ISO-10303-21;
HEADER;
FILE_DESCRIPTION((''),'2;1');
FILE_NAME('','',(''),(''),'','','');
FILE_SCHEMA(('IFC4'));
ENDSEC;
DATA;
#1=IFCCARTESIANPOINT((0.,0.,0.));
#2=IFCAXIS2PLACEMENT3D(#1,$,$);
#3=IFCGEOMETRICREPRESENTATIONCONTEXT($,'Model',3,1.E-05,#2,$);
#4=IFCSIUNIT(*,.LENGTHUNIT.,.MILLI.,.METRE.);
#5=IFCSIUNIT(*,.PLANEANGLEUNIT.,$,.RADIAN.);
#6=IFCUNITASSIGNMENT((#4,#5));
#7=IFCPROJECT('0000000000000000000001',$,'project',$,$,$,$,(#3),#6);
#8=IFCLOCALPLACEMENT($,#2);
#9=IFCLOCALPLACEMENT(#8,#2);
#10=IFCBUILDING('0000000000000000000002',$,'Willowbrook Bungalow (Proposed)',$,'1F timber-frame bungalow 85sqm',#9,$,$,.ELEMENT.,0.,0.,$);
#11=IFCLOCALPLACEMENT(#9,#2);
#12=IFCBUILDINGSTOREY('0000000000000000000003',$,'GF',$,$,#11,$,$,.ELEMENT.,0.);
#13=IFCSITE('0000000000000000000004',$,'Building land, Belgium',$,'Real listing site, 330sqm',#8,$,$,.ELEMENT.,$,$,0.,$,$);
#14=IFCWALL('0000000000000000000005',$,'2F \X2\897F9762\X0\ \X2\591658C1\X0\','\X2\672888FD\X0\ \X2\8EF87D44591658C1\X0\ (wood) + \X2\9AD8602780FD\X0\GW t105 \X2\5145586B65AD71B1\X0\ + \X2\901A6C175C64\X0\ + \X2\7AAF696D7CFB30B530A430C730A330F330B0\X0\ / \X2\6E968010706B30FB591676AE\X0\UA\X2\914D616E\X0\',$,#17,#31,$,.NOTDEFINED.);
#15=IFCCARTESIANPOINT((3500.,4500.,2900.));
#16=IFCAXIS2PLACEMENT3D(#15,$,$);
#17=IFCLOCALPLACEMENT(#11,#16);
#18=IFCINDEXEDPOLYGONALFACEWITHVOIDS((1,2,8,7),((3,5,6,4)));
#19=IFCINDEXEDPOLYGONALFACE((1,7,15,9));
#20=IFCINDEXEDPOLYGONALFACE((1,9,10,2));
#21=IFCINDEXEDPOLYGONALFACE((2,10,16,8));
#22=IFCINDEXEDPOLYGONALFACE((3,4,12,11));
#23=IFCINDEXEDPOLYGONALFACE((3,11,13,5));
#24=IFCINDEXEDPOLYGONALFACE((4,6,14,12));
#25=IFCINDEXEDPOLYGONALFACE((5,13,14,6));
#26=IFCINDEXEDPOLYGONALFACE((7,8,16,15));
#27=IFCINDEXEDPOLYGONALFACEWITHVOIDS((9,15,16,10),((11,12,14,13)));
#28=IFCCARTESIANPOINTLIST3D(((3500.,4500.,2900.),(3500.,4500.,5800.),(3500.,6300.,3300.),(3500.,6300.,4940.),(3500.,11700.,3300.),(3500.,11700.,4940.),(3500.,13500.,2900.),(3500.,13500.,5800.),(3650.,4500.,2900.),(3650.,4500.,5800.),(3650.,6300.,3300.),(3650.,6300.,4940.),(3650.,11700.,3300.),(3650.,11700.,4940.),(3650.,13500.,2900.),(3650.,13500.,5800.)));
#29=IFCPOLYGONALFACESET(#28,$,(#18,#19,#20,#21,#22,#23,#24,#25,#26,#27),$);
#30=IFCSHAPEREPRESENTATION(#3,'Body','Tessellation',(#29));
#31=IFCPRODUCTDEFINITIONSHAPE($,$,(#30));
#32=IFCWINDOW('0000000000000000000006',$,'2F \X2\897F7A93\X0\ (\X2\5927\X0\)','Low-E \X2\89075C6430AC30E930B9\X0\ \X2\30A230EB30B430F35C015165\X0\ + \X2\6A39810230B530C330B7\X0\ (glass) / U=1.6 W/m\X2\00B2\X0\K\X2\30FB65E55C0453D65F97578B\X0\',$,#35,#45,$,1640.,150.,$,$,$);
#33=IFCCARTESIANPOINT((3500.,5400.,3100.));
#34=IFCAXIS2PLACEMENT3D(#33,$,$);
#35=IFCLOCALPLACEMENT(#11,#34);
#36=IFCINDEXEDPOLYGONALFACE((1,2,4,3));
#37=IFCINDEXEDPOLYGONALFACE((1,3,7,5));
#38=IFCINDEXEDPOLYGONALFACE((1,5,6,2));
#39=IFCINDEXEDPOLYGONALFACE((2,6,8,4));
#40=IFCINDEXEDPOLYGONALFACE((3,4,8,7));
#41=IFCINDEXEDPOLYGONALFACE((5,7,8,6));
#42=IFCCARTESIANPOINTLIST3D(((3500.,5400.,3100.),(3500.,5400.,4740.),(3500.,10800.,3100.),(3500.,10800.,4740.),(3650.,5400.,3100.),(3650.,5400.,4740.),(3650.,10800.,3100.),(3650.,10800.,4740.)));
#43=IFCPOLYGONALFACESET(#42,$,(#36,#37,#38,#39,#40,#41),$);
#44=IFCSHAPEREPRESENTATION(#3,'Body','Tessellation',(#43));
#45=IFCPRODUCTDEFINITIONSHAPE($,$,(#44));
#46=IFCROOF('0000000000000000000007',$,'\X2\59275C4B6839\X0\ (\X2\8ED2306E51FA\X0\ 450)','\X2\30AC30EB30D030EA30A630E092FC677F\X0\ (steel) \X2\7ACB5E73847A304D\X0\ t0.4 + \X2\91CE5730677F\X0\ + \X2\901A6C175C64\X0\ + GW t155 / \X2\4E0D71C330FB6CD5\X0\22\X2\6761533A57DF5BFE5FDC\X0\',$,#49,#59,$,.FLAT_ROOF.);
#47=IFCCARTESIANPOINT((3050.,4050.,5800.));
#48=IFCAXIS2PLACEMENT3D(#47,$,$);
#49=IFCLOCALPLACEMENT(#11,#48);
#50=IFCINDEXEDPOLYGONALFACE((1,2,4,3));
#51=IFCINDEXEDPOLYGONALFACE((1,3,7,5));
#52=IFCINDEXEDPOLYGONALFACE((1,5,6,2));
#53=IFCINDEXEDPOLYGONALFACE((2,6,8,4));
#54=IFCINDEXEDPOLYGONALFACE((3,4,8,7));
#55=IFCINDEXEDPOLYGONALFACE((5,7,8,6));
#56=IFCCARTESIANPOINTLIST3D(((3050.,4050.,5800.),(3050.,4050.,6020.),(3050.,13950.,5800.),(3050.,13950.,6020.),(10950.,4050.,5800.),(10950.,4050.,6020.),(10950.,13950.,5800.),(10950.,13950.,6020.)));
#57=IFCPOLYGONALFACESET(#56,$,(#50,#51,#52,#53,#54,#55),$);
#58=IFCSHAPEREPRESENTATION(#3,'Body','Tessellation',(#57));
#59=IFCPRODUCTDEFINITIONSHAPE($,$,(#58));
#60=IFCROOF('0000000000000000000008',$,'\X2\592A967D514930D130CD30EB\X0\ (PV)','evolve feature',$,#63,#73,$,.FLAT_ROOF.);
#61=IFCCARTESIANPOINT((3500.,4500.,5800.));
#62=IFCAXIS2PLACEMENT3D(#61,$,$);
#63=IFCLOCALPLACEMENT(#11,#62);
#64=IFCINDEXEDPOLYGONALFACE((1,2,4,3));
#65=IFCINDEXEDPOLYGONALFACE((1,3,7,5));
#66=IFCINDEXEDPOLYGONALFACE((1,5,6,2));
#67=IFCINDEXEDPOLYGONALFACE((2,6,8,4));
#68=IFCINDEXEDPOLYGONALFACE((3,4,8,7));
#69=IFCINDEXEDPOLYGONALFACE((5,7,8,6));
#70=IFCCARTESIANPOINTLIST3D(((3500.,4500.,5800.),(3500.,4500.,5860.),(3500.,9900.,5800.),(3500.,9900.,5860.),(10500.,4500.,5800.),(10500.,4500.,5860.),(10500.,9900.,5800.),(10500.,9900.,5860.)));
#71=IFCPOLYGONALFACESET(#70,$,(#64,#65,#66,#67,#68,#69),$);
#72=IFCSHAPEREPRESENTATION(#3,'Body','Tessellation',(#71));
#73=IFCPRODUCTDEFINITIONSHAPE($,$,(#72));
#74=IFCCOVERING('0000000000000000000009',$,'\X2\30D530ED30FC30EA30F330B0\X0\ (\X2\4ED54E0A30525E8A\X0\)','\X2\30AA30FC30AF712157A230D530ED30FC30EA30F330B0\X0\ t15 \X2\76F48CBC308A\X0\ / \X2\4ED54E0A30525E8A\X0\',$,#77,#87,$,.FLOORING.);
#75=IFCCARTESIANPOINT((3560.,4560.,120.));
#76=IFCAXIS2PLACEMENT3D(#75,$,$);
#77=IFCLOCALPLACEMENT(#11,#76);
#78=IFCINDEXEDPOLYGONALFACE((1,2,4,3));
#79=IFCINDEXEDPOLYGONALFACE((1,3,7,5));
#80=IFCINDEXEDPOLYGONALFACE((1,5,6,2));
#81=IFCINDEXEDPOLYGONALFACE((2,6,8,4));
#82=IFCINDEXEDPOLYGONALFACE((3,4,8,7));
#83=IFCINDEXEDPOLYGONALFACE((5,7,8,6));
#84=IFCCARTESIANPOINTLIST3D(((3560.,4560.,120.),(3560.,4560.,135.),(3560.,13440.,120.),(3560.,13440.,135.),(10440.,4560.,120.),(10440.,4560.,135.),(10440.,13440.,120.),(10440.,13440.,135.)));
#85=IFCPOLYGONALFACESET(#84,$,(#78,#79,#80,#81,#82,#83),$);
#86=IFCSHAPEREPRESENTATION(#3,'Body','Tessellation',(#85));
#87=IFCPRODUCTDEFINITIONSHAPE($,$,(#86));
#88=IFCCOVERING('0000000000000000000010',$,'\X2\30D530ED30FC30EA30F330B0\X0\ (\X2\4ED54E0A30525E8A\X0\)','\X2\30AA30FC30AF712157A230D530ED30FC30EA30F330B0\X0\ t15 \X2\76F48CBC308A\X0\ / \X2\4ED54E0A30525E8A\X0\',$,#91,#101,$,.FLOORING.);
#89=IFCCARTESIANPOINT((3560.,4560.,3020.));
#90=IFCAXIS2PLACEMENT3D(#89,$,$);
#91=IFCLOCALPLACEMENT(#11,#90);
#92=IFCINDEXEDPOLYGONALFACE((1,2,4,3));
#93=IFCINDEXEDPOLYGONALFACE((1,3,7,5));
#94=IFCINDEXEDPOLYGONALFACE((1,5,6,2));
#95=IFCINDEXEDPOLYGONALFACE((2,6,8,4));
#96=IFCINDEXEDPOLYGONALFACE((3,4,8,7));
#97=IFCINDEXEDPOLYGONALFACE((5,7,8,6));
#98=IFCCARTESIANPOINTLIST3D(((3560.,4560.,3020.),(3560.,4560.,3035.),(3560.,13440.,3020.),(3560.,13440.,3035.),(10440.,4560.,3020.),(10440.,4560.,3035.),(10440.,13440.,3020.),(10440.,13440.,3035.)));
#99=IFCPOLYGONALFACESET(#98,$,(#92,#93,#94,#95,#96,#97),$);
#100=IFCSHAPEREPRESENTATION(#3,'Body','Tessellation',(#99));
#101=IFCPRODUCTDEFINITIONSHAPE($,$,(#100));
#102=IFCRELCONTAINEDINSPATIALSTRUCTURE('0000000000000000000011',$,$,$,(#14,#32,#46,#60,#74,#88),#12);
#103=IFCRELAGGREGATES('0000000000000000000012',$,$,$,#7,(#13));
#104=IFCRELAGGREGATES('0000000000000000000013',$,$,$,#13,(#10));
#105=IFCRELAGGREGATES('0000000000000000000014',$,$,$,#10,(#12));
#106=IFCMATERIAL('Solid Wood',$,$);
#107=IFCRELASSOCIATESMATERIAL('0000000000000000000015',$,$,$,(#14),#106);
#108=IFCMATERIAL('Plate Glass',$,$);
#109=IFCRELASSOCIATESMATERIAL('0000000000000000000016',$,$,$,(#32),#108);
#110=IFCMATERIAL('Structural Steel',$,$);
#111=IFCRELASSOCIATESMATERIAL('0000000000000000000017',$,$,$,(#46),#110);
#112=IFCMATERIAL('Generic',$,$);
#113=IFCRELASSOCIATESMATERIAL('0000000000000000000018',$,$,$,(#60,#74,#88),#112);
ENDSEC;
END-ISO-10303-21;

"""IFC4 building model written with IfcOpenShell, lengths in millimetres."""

from ifc_helpers import new_model, si_unit, frame, frame_2d, origin, place, context, project, spatial, rectangle, extrude, material, element, fill, save


model = new_model("IFC4")

# Units and contexts
model_context = context("Model", 3, precision=1e-05, world=origin())
ifc_project = project(units=[si_unit("LENGTHUNIT", "METRE", prefix="MILLI"), si_unit("PLANEANGLEUNIT", "RADIAN")], contexts=[model_context])

# Site, building, storey
site_placement = place(None, origin())
site = spatial("IfcSite", under=ifc_project, at=site_placement, Name="Building land, Belgium", ObjectType="Real listing site, 330sqm", CompositionType="ELEMENT", RefElevation=0.0)
building_placement = place(site_placement, origin())
building = spatial("IfcBuilding", under=site, at=building_placement, Name="Willowbrook Bungalow (Proposed)", ObjectType="1F timber-frame bungalow 85sqm", CompositionType="ELEMENT", ElevationOfRefHeight=0.0, ElevationOfTerrain=0.0)
storey_placement = place(building_placement, origin())
storey = spatial("IfcBuildingStorey", under=building, at=storey_placement, Name="GF", CompositionType="ELEMENT", Elevation=0.0)

# Shared definitions
ifc_material_1 = material(Name="Solid Wood")
ifc_material_2 = material(Name="Generic")

# Shared definitions
ifc_material_3 = material(Name="Plate Glass")

# Wall, opening, window
wall_1_placement = place(storey_placement, frame((3500.0, 4500.0, 2900.0)))
wall_1 = element("IfcWall", 1, at=wall_1_placement, inside=storey, material=ifc_material_1, Name="2F 西面 外壁", Description="木製 軸組外壁 (wood) + 高性能GW t105 充填断熱 + 通気層 + 窯業系サイディング / 準耐火・外皮UA配慮", PredefinedType="NOTDEFINED", context=model_context, shape_type="SweptSolid", body=[
    extrude(rectangle(XDim=150.0, YDim=9000.0, at=frame_2d((75.0, 4500.0))), frame((3500.0, 4500.0, 2900.0)), (0.0, 0.0, 1.0), 2900.0),
])
opening_1_placement = place(storey_placement, frame((3500.0, 5400.0, 3100.0)))
opening_1 = element("IfcOpeningElement", 2, at=opening_1_placement, cuts=wall_1, PredefinedType="NOTDEFINED", context=model_context, shape_type="SweptSolid", body=[
    extrude(rectangle(XDim=150.0, YDim=5400.0, at=frame_2d((75.0, 2700.0))), frame((3500.0, 5400.0, 3100.0)), (0.0, 0.0, 1.0), 1640.0),
])
window_1_placement = place(storey_placement, frame((3500.0, 5400.0, 3100.0)))
window_1 = element("IfcWindow", 3, at=window_1_placement, inside=storey, material=ifc_material_3, Name="2F 西窓 (大)", Description="Low-E 複層ガラス アルゴン封入 + 樹脂サッシ (glass) / U=1.6 W/m²K・日射取得型", OverallHeight=1640.0, OverallWidth=150.0, context=model_context, shape_type="SweptSolid", body=[
    extrude(rectangle(XDim=150.0, YDim=5400.0, at=frame_2d((75.0, 2700.0))), frame((3500.0, 5400.0, 3100.0)), (0.0, 0.0, 1.0), 1640.0),
])
fill(opening_1, window_1)

# Roofs
ifc_material_4 = material(Name="Structural Steel")
roof_1_placement = place(storey_placement, frame((3050.0, 4050.0, 5800.0)))
element("IfcRoof", 4, at=roof_1_placement, inside=storey, material=ifc_material_4, Name="大屋根 (軒の出 450)", Description="ガルバリウム鋼板 (steel) 立平葺き t0.4 + 野地板 + 通気層 + GW t155 / 不燃・法22条区域対応", PredefinedType="FLAT_ROOF", context=model_context, shape_type="SweptSolid", body=[
    extrude(rectangle(XDim=7900.0, YDim=9900.0, at=frame_2d((3950.0, 4950.0))), frame((3050.0, 4050.0, 5800.0)), (0.0, 0.0, 1.0), 220.0),
])
roof_2_placement = place(storey_placement, frame((3500.0, 4500.0, 5800.0)))
element("IfcRoof", 5, at=roof_2_placement, inside=storey, material=ifc_material_2, Name="太陽光パネル (PV)", Description="evolve feature", PredefinedType="FLAT_ROOF", context=model_context, shape_type="SweptSolid", body=[
    extrude(rectangle(XDim=7000.0, YDim=5400.0, at=frame_2d((3500.0, 2700.0))), frame((3500.0, 4500.0, 5800.0)), (0.0, 0.0, 1.0), 60.0),
])

# Coverings
covering_1_placement = place(storey_placement, frame((3560.0, 4560.0, 120.0)))
element("IfcCovering", 6, at=covering_1_placement, inside=storey, material=ifc_material_2, Name="フローリング (仕上げ床)", Description="オーク無垢フローリング t15 直貼り / 仕上げ床", PredefinedType="FLOORING", context=model_context, shape_type="SweptSolid", body=[
    extrude(rectangle(XDim=6880.0, YDim=8880.0, at=frame_2d((3440.0, 4440.0))), frame((3560.0, 4560.0, 120.0)), (0.0, 0.0, 1.0), 15.0),
])
covering_2_placement = place(storey_placement, frame((3560.0, 4560.0, 3020.0)))
element("IfcCovering", 7, at=covering_2_placement, inside=storey, material=ifc_material_2, Name="フローリング (仕上げ床)", Description="オーク無垢フローリング t15 直貼り / 仕上げ床", PredefinedType="FLOORING", context=model_context, shape_type="SweptSolid", body=[
    extrude(rectangle(XDim=6880.0, YDim=8880.0, at=frame_2d((3440.0, 4440.0))), frame((3560.0, 4560.0, 3020.0)), (0.0, 0.0, 1.0), 15.0),
])

save(model, "model.ifc")
